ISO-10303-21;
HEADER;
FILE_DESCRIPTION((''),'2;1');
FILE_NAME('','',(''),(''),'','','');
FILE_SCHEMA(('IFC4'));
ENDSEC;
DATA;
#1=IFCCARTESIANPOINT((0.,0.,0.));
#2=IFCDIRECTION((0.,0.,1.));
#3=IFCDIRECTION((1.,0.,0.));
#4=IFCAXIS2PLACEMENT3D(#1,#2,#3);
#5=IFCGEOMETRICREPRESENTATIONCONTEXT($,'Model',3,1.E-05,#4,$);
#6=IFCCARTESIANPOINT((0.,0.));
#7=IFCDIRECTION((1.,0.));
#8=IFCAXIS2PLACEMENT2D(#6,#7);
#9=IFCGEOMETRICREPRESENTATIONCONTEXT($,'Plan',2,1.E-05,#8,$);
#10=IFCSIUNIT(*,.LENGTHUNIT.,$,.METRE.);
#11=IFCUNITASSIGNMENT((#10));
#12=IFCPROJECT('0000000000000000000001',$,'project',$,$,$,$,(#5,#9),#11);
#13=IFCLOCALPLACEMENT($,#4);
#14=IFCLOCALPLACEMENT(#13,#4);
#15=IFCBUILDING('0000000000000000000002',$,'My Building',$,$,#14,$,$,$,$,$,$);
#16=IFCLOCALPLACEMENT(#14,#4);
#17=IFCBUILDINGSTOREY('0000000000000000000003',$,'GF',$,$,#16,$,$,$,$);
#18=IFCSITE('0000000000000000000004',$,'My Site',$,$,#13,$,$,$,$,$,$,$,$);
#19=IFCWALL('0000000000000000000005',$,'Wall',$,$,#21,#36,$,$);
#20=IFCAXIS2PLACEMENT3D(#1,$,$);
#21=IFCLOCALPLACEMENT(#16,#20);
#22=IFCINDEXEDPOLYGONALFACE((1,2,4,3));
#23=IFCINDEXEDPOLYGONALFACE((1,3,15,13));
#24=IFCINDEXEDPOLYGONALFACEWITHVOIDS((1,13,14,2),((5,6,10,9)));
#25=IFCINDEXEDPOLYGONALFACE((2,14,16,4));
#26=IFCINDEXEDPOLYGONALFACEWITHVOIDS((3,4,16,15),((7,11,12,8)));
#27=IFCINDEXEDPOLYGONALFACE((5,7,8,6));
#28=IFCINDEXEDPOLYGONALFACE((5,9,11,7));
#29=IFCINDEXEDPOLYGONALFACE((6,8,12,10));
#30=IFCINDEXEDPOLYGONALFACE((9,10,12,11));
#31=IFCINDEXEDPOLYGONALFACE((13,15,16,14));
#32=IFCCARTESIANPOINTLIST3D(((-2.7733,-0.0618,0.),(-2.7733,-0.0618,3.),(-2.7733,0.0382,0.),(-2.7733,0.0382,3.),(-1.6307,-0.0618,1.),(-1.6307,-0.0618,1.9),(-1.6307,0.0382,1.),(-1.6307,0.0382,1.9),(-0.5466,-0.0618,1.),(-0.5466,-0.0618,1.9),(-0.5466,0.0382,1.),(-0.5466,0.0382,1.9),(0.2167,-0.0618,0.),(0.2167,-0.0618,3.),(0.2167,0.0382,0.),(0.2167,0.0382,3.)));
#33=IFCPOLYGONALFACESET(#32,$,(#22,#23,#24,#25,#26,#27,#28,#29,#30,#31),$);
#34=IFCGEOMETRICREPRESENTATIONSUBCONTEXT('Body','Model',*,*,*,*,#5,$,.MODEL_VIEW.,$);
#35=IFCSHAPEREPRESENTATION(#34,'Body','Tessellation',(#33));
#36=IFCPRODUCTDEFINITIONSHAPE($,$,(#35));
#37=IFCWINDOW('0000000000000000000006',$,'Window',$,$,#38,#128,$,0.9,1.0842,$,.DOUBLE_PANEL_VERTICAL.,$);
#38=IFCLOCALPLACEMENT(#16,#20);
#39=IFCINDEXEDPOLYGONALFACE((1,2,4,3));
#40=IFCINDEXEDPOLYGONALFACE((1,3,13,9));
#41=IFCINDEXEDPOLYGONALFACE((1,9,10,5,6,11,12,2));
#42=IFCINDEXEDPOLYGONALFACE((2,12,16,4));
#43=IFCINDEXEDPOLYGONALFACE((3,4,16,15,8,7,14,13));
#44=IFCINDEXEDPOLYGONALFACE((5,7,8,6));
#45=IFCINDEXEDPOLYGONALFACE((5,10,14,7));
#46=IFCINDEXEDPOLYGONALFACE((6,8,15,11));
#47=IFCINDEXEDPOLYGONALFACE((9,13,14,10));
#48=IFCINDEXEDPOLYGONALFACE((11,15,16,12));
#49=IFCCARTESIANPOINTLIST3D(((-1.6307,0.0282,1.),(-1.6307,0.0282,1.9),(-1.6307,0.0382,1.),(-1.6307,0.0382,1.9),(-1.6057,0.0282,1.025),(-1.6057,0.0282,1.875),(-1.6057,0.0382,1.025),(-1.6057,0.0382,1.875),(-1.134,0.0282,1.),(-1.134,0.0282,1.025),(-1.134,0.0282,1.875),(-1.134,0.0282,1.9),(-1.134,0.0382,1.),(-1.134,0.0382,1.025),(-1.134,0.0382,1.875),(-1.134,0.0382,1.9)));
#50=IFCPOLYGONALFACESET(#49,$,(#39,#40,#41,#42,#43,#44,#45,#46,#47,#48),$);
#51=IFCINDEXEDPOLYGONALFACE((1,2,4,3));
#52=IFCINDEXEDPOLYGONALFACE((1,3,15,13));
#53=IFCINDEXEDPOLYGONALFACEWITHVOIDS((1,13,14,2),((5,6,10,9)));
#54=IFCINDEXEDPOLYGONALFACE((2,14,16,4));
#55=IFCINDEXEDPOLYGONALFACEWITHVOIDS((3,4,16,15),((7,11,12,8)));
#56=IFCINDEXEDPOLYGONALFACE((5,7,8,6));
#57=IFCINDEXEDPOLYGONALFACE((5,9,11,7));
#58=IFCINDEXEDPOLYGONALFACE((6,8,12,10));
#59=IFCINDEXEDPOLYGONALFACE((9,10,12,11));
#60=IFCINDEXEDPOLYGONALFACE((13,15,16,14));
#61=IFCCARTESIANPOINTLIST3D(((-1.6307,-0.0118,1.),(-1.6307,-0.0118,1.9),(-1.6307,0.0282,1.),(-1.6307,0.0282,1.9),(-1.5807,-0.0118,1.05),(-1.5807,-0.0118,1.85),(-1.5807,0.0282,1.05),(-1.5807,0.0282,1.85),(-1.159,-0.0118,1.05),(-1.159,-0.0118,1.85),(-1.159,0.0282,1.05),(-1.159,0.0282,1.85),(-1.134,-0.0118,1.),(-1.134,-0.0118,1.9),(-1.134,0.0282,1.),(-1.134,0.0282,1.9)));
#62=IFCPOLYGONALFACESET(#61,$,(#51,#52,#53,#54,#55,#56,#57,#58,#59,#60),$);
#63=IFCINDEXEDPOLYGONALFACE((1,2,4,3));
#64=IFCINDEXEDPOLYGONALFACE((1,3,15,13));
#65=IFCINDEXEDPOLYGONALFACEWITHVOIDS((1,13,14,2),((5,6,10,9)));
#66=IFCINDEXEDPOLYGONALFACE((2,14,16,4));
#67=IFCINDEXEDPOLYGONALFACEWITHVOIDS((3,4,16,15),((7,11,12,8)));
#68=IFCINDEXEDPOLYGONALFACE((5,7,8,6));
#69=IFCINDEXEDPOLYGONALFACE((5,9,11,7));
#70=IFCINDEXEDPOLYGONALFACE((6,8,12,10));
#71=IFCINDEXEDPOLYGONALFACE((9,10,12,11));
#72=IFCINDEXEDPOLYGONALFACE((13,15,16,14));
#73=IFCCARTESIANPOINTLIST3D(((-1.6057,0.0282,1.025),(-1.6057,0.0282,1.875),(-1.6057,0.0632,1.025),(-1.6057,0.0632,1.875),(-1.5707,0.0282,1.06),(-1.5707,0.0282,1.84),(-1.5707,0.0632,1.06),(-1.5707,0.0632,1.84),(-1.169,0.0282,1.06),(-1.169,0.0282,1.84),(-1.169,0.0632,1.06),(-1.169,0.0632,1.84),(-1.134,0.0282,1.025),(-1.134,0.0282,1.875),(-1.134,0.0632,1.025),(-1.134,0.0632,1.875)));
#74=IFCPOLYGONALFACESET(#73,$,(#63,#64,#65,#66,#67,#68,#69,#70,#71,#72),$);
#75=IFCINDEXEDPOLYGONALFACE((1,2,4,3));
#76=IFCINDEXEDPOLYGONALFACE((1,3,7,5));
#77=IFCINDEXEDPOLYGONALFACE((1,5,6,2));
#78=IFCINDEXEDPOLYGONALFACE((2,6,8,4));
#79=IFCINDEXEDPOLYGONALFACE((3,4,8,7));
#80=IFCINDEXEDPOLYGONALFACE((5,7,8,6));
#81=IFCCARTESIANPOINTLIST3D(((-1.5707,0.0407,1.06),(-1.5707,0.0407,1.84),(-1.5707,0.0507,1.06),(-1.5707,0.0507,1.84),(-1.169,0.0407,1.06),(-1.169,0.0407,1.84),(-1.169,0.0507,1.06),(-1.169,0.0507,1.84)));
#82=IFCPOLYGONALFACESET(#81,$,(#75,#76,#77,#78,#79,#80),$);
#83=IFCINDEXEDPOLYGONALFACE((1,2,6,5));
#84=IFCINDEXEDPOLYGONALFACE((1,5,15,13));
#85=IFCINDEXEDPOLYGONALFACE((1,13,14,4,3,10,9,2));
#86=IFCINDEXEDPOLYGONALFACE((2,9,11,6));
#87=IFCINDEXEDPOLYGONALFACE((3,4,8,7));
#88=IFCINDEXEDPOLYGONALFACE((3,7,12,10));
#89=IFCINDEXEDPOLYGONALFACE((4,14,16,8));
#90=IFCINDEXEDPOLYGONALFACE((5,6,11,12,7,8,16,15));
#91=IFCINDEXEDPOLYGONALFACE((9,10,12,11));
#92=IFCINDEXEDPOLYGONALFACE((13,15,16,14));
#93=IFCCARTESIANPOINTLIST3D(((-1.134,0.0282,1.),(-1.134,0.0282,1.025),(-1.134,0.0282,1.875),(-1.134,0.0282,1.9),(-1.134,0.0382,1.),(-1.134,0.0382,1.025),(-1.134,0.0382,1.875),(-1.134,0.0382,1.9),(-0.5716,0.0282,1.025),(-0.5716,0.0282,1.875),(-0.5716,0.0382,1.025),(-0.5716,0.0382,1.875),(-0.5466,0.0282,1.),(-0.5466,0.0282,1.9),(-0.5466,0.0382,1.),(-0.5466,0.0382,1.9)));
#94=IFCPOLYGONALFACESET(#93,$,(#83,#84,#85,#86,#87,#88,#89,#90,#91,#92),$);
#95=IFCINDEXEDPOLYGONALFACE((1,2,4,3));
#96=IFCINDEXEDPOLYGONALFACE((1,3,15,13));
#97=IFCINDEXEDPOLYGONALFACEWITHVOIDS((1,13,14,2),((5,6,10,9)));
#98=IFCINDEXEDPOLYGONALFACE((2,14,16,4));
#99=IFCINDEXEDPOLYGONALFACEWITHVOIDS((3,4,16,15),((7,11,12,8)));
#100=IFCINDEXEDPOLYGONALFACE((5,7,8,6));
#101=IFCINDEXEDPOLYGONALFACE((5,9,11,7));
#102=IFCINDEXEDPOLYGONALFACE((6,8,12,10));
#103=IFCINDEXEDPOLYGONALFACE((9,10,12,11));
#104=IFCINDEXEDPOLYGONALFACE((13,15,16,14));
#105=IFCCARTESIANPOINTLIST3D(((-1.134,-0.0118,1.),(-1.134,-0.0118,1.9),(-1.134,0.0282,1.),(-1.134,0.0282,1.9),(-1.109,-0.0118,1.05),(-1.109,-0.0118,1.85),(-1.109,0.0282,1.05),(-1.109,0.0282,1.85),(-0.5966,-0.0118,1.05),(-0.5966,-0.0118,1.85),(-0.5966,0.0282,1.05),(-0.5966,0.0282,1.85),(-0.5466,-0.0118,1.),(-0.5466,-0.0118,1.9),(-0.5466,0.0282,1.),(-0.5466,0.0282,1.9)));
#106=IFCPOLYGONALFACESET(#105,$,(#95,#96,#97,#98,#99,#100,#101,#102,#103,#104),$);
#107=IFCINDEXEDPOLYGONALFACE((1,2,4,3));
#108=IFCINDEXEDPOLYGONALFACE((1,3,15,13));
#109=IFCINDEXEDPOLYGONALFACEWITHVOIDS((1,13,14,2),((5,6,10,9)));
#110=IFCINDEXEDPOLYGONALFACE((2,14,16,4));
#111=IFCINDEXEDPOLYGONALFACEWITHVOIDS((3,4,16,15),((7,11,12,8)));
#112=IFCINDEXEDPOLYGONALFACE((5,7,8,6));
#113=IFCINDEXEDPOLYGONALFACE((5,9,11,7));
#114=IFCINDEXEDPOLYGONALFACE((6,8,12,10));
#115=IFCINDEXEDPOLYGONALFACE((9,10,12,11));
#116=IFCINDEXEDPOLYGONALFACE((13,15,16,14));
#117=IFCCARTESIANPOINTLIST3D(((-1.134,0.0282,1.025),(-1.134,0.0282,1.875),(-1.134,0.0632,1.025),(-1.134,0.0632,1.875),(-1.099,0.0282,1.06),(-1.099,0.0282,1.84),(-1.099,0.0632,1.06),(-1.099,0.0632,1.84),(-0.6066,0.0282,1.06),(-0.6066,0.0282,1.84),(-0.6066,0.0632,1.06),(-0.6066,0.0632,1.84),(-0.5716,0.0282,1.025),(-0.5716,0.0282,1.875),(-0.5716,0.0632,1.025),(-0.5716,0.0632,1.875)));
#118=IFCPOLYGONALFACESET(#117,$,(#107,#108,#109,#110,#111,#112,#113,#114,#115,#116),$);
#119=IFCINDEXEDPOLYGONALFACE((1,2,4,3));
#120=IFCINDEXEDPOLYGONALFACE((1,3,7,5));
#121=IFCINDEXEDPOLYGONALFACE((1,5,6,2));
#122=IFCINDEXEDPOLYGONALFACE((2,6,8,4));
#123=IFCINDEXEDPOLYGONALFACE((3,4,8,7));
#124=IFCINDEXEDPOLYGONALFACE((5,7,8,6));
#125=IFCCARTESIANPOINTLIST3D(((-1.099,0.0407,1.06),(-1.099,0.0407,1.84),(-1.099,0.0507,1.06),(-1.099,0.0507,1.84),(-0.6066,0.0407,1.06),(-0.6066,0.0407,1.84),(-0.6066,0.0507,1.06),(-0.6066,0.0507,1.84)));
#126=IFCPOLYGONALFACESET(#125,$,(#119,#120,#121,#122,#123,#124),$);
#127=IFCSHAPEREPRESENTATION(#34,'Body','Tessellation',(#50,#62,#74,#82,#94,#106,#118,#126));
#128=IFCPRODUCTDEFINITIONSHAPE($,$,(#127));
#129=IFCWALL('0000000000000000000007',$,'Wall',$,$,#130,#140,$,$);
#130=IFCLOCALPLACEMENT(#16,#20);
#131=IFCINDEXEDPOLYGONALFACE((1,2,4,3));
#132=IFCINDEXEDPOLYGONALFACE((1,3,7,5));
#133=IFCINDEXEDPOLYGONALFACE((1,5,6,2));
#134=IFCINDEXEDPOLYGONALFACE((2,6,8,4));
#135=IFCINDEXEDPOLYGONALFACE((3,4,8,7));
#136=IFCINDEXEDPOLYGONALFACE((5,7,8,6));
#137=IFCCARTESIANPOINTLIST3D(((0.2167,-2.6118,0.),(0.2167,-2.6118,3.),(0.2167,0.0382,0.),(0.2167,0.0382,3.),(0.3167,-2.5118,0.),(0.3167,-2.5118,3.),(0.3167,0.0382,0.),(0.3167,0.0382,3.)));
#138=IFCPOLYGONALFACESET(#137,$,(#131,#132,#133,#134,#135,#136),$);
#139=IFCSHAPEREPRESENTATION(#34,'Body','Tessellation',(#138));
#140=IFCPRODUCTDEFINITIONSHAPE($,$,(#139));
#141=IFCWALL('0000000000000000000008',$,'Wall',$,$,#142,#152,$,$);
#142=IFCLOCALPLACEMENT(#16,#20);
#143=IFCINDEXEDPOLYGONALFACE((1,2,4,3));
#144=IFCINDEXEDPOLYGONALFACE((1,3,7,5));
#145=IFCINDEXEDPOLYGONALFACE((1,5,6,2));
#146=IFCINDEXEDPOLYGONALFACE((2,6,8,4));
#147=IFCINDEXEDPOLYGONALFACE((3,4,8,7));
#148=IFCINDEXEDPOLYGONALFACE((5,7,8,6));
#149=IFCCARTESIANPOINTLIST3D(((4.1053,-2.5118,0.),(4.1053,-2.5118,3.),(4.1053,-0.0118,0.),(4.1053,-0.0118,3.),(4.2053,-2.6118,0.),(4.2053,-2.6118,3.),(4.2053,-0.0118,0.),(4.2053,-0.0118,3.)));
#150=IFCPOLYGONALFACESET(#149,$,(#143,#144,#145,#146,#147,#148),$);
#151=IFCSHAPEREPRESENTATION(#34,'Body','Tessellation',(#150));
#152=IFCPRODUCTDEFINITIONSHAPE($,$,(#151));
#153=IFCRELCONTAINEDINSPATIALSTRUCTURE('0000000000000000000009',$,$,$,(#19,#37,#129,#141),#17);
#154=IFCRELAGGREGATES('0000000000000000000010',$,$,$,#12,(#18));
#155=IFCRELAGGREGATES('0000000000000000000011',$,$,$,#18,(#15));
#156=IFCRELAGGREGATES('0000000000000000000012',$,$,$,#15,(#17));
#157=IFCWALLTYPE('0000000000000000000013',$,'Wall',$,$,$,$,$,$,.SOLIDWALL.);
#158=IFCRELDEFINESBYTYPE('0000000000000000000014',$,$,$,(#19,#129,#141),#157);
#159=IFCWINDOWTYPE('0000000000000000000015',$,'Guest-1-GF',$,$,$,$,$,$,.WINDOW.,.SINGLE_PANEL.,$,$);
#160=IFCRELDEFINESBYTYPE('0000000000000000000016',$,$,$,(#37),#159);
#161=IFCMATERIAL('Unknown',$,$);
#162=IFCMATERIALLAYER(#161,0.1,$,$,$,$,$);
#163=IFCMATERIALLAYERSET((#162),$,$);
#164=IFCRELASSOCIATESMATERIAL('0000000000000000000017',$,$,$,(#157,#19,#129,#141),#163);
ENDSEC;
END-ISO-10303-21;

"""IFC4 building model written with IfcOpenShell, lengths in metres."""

from ifc_helpers import new_model, entity, si_unit, frame, origin_with_axes, origin_2d_with_axis, place, context, subcontext, project, spatial, line, indexed_curve, outline, extrude, shape, source, transform, mapped, material, layer, layer_set, layer_usage, type_object, type_shapes, element, fill, save


model = new_model("IFC4")

# Units and contexts
model_context = context("Model", 3, precision=1e-05, world=origin_with_axes())
plan_context = context("Plan", 2, precision=1e-05, world=origin_2d_with_axis())
body_context_1 = subcontext(model_context, "Body", "Model", "MODEL_VIEW")
body_context_2 = subcontext(plan_context, "Body", "Plan", "PLAN_VIEW")
ifc_project = project(units=[si_unit("LENGTHUNIT", "METRE")], contexts=[model_context, plan_context])

# Site, building, storey
site_placement = place(None, origin_with_axes())
site = spatial("IfcSite", under=ifc_project, at=site_placement, Name="My Site")
building_placement = place(site_placement, origin_with_axes())
building = spatial("IfcBuilding", under=site, at=building_placement, Name="My Building")
storey_placement = place(building_placement, origin_with_axes())
storey = spatial("IfcBuildingStorey", under=building, at=storey_placement, Name="GF")

# Shared definitions
ifc_material = material(Name="Unknown")

# Wall, opening, window
ifc_layer_1 = layer(ifc_material, 0.1)
ifc_layer_set_1 = layer_set([ifc_layer_1])
ifc_layer_usage_1 = layer_usage(ifc_layer_set_1, "AXIS2", "POSITIVE", 0.0)
wall_type = type_object("IfcWallType", Name="Wall", PredefinedType="SOLIDWALL", material=ifc_layer_set_1)
wall_1_placement = place(storey_placement, frame((0.2167, 0.0382, 0.0), z_axis=(0.0, 0.0, 1.0), x_axis=(-1.0, 0.0, 0.0)))
wall_1 = element("IfcWall", 1, at=wall_1_placement, inside=storey, type_object=wall_type, material=ifc_layer_usage_1, Name="Wall", context=body_context_1, shape_type="SweptSolid", body=[
    extrude(outline(indexed_curve([(0.0, 0.0), (0.0, 0.1), (2.99, 0.1), (2.99, 0.0)], segments=[line(1, 2, 3, 4, 1)])), origin_with_axes(), (0.0, 0.0, 1.0), 3.0),
])
shared_shape_1 = source(origin_with_axes(), body_context_1, "Body", "SweptSolid", [
    extrude(outline(indexed_curve([(0.0, 0.0), (1.0842, 0.0), (1.0842, 0.9), (0.0, 0.9)], segments=[line(1, 2, 3, 4, 1)])), frame((0.0, -0.6, 0.0), z_axis=(0.0, -1.0, 0.0), x_axis=(1.0, 0.0, 0.0)), (0.0, 0.0, -1.0), 1.2),
])
opening_1_placement = place(wall_1_placement, frame((1.8474, 0.1, 1.0), z_axis=(0.0, 0.0, 1.0), x_axis=(-1.0, 0.0, 0.0)))
opening_1 = element("IfcOpeningElement", 2, at=opening_1_placement, cuts=wall_1, PredefinedType="OPENING", context=body_context_1, shape_type="MappedRepresentation", body=[
    mapped(shared_shape_1, transform((0.0, 0.0, 0.0), x_axis=(1.0, 0.0, 0.0), y_axis=(0.0, 1.0, 0.0), z_axis=(0.0, 0.0, 1.0), scale=1.0)),
])
window_type_1 = type_object("IfcWindowType", Name="Guest-1-GF", PartitioningType="SINGLE_PANEL", PredefinedType="WINDOW")
shared_shape_2 = source(origin_with_axes(), body_context_1, "Body", "SweptSolid", [
    extrude(outline(indexed_curve([(0.4967, 0.0), (0.0, 0.0), (0.0, 0.9), (0.4967, 0.9), (0.4967, 0.875), (0.025, 0.875), (0.025, 0.025), (0.4967, 0.025)], segments=[line(1, 2, 3, 4, 5, 6, 7, 8, 1)])), frame((0.0, 0.09, 0.0), z_axis=(0.0, -1.0, 0.0), x_axis=(1.0, 0.0, 0.0)), (0.0, 0.0, -1.0), 0.01),
    extrude(outline(indexed_curve([(0.0, 0.0), (0.4967, 0.0), (0.4967, 0.9), (0.0, 0.9)], segments=[line(1, 2, 3, 4, 1)]), holes=[indexed_curve([(0.05, 0.05), (0.4717, 0.05), (0.4717, 0.85), (0.05, 0.85)], segments=[line(1, 2, 3, 4, 1)])]), frame((0.0, 0.05, 0.0), z_axis=(0.0, -1.0, 0.0), x_axis=(1.0, 0.0, 0.0)), (0.0, 0.0, -1.0), 0.04),
    extrude(outline(indexed_curve([(0.0, 0.0), (0.4717, 0.0), (0.4717, 0.85), (0.0, 0.85)], segments=[line(1, 2, 3, 4, 1)]), holes=[indexed_curve([(0.035, 0.035), (0.4367, 0.035), (0.4367, 0.815), (0.035, 0.815)], segments=[line(1, 2, 3, 4, 1)])]), frame((0.025, 0.09, 0.025), z_axis=(0.0, -1.0, 0.0), x_axis=(1.0, 0.0, 0.0)), (0.0, 0.0, -1.0), 0.035),
    extrude(outline(indexed_curve([(0.035, 0.035), (0.4367, 0.035), (0.4367, 0.815), (0.035, 0.815)], segments=[line(1, 2, 3, 4, 1)])), frame((0.025, 0.1025, 0.025), z_axis=(0.0, -1.0, 0.0), x_axis=(1.0, 0.0, 0.0)), (0.0, 0.0, -1.0), 0.01),
    extrude(outline(indexed_curve([(0.0, 0.9), (0.5874, 0.9), (0.5874, 0.0), (0.0, 0.0), (0.0, 0.025), (0.5624, 0.025), (0.5624, 0.875), (0.0, 0.875)], segments=[line(1, 2, 3, 4, 5, 6, 7, 8, 1)])), frame((0.4967, 0.09, 0.0), z_axis=(0.0, -1.0, 0.0), x_axis=(1.0, 0.0, 0.0)), (0.0, 0.0, -1.0), 0.01),
    extrude(outline(indexed_curve([(0.0, 0.0), (0.5874, 0.0), (0.5874, 0.9), (0.0, 0.9)], segments=[line(1, 2, 3, 4, 1)]), holes=[indexed_curve([(0.025, 0.05), (0.5374, 0.05), (0.5374, 0.85), (0.025, 0.85)], segments=[line(1, 2, 3, 4, 1)])]), frame((0.4967, 0.05, 0.0), z_axis=(0.0, -1.0, 0.0), x_axis=(1.0, 0.0, 0.0)), (0.0, 0.0, -1.0), 0.04),
    extrude(outline(indexed_curve([(0.0, 0.0), (0.5624, 0.0), (0.5624, 0.85), (0.0, 0.85)], segments=[line(1, 2, 3, 4, 1)]), holes=[indexed_curve([(0.035, 0.035), (0.5274, 0.035), (0.5274, 0.815), (0.035, 0.815)], segments=[line(1, 2, 3, 4, 1)])]), frame((0.4967, 0.09, 0.025), z_axis=(0.0, -1.0, 0.0), x_axis=(1.0, 0.0, 0.0)), (0.0, 0.0, -1.0), 0.035),
    extrude(outline(indexed_curve([(0.035, 0.035), (0.5274, 0.035), (0.5274, 0.815), (0.035, 0.815)], segments=[line(1, 2, 3, 4, 1)])), frame((0.4967, 0.1025, 0.025), z_axis=(0.0, -1.0, 0.0), x_axis=(1.0, 0.0, 0.0)), (0.0, 0.0, -1.0), 0.01),
])
shared_shape_3 = source(origin_with_axes(), body_context_2, "Body", "Curve2D", [
    entity("IfcIndexedPolyCurve", entity("IfcCartesianPointList2D", [[0.05, 0.05], [0.4717, 0.05]])),
    entity("IfcIndexedPolyCurve", entity("IfcCartesianPointList2D", [[0.0, 0.1], [0.025, 0.1], [0.025, 0.09], [0.05, 0.09], [0.05, 0.05], [0.0, 0.05]]), [entity("IfcLineIndex", [1, 2, 3, 4, 5, 6, 1])]),
    entity("IfcIndexedPolyCurve", entity("IfcCartesianPointList2D", [[0.4967, 0.1], [0.4967, 0.1], [0.4967, 0.09], [0.4717, 0.09], [0.4717, 0.05], [0.4967, 0.05]])),
    entity("IfcIndexedPolyCurve", entity("IfcCartesianPointList2D", [[0.025, 0.09], [0.06, 0.09], [0.06, 0.125], [0.025, 0.125]]), [entity("IfcLineIndex", [1, 2, 3, 4, 1])]),
    entity("IfcIndexedPolyCurve", entity("IfcCartesianPointList2D", [[0.4967, 0.09], [0.4617, 0.09], [0.4617, 0.125], [0.4967, 0.125]]), [entity("IfcLineIndex", [1, 2, 3, 4, 1])]),
    entity("IfcIndexedPolyCurve", entity("IfcCartesianPointList2D", [[0.06, 0.09], [0.4617, 0.09]])),
    entity("IfcIndexedPolyCurve", entity("IfcCartesianPointList2D", [[0.06, 0.125], [0.4617, 0.125]])),
    entity("IfcIndexedPolyCurve", entity("IfcCartesianPointList2D", [[0.06, 0.1075], [0.4617, 0.1075]])),
    entity("IfcIndexedPolyCurve", entity("IfcCartesianPointList2D", [[0.5217, 0.05], [1.0342, 0.05]])),
    entity("IfcIndexedPolyCurve", entity("IfcCartesianPointList2D", [[0.4967, 0.1], [0.4967, 0.1], [0.4967, 0.09], [0.5217, 0.09], [0.5217, 0.05], [0.4967, 0.05]])),
    entity("IfcIndexedPolyCurve", entity("IfcCartesianPointList2D", [[1.0842, 0.1], [1.0592, 0.1], [1.0592, 0.09], [1.0342, 0.09], [1.0342, 0.05], [1.0842, 0.05]]), [entity("IfcLineIndex", [1, 2, 3, 4, 5, 6, 1])]),
    entity("IfcIndexedPolyCurve", entity("IfcCartesianPointList2D", [[0.4967, 0.09], [0.5317, 0.09], [0.5317, 0.125], [0.4967, 0.125]]), [entity("IfcLineIndex", [1, 2, 3, 4, 1])]),
    entity("IfcIndexedPolyCurve", entity("IfcCartesianPointList2D", [[1.0592, 0.09], [1.0242, 0.09], [1.0242, 0.125], [1.0592, 0.125]]), [entity("IfcLineIndex", [1, 2, 3, 4, 1])]),
    entity("IfcIndexedPolyCurve", entity("IfcCartesianPointList2D", [[0.5317, 0.09], [1.0242, 0.09]])),
    entity("IfcIndexedPolyCurve", entity("IfcCartesianPointList2D", [[0.5317, 0.125], [1.0242, 0.125]])),
    entity("IfcIndexedPolyCurve", entity("IfcCartesianPointList2D", [[0.5317, 0.1075], [1.0242, 0.1075]])),
])
type_shapes(window_type_1, [shared_shape_2, shared_shape_3])
window_1_placement = place(opening_1_placement, frame((0.0, 0.0, 0.0), z_axis=(0.0, 0.0, 1.0), x_axis=(1.0, 0.0, 0.0)))
window_1 = element("IfcWindow", 3, at=window_1_placement, inside=storey, type_object=window_type_1, Name="Window", OverallHeight=0.9, OverallWidth=1.0842, PartitioningType="DOUBLE_PANEL_VERTICAL", shapes=[
    shape(body_context_1, "Body", "MappedRepresentation", [mapped(shared_shape_2, transform((0.0, 0.0, 0.0), x_axis=(1.0, 0.0, 0.0), y_axis=(0.0, 1.0, 0.0), z_axis=(0.0, 0.0, 1.0), scale=1.0))]),
    shape(body_context_2, "Body", "MappedRepresentation", [mapped(shared_shape_3, transform((0.0, 0.0, 0.0), x_axis=(1.0, 0.0, 0.0), y_axis=(0.0, 1.0, 0.0), z_axis=(0.0, 0.0, 1.0), scale=1.0))]),
])
fill(opening_1, window_1)

# Wall
ifc_layer_usage_2 = layer_usage(ifc_layer_set_1, "AXIS2", "POSITIVE", 0.0)
wall_2_placement = place(storey_placement, frame((0.2167, 0.0382, 0.0), z_axis=(0.0, 0.0, 1.0), x_axis=(0.0, -1.0, 0.0)))
element("IfcWall", 4, at=wall_2_placement, inside=storey, type_object=wall_type, material=ifc_layer_usage_2, Name="Wall", context=body_context_1, shape_type="SweptSolid", body=[
    extrude(outline(indexed_curve([(0.0, 0.0), (0.0, 0.1), (2.55, 0.1), (2.65, 0.0)], segments=[line(1, 2, 3, 4, 1)])), origin_with_axes(), (0.0, 0.0, 1.0), 3.0),
])

# Wall
ifc_layer_usage_3 = layer_usage(ifc_layer_set_1, "AXIS2", "POSITIVE", 0.0)
wall_3_placement = place(storey_placement, frame((4.2053, -2.6118, 0.0), z_axis=(0.0, 0.0, 1.0), x_axis=(0.0, 1.0, 0.0)))
element("IfcWall", 5, at=wall_3_placement, inside=storey, type_object=wall_type, material=ifc_layer_usage_3, Name="Wall", context=body_context_1, shape_type="SweptSolid", body=[
    extrude(outline(indexed_curve([(0.0, 0.0), (0.1, 0.1), (2.6, 0.1), (2.6, 0.0)], segments=[line(1, 2, 3, 4, 1)])), origin_with_axes(), (0.0, 0.0, 1.0), 3.0),
])

save(model, "model.ifc")
